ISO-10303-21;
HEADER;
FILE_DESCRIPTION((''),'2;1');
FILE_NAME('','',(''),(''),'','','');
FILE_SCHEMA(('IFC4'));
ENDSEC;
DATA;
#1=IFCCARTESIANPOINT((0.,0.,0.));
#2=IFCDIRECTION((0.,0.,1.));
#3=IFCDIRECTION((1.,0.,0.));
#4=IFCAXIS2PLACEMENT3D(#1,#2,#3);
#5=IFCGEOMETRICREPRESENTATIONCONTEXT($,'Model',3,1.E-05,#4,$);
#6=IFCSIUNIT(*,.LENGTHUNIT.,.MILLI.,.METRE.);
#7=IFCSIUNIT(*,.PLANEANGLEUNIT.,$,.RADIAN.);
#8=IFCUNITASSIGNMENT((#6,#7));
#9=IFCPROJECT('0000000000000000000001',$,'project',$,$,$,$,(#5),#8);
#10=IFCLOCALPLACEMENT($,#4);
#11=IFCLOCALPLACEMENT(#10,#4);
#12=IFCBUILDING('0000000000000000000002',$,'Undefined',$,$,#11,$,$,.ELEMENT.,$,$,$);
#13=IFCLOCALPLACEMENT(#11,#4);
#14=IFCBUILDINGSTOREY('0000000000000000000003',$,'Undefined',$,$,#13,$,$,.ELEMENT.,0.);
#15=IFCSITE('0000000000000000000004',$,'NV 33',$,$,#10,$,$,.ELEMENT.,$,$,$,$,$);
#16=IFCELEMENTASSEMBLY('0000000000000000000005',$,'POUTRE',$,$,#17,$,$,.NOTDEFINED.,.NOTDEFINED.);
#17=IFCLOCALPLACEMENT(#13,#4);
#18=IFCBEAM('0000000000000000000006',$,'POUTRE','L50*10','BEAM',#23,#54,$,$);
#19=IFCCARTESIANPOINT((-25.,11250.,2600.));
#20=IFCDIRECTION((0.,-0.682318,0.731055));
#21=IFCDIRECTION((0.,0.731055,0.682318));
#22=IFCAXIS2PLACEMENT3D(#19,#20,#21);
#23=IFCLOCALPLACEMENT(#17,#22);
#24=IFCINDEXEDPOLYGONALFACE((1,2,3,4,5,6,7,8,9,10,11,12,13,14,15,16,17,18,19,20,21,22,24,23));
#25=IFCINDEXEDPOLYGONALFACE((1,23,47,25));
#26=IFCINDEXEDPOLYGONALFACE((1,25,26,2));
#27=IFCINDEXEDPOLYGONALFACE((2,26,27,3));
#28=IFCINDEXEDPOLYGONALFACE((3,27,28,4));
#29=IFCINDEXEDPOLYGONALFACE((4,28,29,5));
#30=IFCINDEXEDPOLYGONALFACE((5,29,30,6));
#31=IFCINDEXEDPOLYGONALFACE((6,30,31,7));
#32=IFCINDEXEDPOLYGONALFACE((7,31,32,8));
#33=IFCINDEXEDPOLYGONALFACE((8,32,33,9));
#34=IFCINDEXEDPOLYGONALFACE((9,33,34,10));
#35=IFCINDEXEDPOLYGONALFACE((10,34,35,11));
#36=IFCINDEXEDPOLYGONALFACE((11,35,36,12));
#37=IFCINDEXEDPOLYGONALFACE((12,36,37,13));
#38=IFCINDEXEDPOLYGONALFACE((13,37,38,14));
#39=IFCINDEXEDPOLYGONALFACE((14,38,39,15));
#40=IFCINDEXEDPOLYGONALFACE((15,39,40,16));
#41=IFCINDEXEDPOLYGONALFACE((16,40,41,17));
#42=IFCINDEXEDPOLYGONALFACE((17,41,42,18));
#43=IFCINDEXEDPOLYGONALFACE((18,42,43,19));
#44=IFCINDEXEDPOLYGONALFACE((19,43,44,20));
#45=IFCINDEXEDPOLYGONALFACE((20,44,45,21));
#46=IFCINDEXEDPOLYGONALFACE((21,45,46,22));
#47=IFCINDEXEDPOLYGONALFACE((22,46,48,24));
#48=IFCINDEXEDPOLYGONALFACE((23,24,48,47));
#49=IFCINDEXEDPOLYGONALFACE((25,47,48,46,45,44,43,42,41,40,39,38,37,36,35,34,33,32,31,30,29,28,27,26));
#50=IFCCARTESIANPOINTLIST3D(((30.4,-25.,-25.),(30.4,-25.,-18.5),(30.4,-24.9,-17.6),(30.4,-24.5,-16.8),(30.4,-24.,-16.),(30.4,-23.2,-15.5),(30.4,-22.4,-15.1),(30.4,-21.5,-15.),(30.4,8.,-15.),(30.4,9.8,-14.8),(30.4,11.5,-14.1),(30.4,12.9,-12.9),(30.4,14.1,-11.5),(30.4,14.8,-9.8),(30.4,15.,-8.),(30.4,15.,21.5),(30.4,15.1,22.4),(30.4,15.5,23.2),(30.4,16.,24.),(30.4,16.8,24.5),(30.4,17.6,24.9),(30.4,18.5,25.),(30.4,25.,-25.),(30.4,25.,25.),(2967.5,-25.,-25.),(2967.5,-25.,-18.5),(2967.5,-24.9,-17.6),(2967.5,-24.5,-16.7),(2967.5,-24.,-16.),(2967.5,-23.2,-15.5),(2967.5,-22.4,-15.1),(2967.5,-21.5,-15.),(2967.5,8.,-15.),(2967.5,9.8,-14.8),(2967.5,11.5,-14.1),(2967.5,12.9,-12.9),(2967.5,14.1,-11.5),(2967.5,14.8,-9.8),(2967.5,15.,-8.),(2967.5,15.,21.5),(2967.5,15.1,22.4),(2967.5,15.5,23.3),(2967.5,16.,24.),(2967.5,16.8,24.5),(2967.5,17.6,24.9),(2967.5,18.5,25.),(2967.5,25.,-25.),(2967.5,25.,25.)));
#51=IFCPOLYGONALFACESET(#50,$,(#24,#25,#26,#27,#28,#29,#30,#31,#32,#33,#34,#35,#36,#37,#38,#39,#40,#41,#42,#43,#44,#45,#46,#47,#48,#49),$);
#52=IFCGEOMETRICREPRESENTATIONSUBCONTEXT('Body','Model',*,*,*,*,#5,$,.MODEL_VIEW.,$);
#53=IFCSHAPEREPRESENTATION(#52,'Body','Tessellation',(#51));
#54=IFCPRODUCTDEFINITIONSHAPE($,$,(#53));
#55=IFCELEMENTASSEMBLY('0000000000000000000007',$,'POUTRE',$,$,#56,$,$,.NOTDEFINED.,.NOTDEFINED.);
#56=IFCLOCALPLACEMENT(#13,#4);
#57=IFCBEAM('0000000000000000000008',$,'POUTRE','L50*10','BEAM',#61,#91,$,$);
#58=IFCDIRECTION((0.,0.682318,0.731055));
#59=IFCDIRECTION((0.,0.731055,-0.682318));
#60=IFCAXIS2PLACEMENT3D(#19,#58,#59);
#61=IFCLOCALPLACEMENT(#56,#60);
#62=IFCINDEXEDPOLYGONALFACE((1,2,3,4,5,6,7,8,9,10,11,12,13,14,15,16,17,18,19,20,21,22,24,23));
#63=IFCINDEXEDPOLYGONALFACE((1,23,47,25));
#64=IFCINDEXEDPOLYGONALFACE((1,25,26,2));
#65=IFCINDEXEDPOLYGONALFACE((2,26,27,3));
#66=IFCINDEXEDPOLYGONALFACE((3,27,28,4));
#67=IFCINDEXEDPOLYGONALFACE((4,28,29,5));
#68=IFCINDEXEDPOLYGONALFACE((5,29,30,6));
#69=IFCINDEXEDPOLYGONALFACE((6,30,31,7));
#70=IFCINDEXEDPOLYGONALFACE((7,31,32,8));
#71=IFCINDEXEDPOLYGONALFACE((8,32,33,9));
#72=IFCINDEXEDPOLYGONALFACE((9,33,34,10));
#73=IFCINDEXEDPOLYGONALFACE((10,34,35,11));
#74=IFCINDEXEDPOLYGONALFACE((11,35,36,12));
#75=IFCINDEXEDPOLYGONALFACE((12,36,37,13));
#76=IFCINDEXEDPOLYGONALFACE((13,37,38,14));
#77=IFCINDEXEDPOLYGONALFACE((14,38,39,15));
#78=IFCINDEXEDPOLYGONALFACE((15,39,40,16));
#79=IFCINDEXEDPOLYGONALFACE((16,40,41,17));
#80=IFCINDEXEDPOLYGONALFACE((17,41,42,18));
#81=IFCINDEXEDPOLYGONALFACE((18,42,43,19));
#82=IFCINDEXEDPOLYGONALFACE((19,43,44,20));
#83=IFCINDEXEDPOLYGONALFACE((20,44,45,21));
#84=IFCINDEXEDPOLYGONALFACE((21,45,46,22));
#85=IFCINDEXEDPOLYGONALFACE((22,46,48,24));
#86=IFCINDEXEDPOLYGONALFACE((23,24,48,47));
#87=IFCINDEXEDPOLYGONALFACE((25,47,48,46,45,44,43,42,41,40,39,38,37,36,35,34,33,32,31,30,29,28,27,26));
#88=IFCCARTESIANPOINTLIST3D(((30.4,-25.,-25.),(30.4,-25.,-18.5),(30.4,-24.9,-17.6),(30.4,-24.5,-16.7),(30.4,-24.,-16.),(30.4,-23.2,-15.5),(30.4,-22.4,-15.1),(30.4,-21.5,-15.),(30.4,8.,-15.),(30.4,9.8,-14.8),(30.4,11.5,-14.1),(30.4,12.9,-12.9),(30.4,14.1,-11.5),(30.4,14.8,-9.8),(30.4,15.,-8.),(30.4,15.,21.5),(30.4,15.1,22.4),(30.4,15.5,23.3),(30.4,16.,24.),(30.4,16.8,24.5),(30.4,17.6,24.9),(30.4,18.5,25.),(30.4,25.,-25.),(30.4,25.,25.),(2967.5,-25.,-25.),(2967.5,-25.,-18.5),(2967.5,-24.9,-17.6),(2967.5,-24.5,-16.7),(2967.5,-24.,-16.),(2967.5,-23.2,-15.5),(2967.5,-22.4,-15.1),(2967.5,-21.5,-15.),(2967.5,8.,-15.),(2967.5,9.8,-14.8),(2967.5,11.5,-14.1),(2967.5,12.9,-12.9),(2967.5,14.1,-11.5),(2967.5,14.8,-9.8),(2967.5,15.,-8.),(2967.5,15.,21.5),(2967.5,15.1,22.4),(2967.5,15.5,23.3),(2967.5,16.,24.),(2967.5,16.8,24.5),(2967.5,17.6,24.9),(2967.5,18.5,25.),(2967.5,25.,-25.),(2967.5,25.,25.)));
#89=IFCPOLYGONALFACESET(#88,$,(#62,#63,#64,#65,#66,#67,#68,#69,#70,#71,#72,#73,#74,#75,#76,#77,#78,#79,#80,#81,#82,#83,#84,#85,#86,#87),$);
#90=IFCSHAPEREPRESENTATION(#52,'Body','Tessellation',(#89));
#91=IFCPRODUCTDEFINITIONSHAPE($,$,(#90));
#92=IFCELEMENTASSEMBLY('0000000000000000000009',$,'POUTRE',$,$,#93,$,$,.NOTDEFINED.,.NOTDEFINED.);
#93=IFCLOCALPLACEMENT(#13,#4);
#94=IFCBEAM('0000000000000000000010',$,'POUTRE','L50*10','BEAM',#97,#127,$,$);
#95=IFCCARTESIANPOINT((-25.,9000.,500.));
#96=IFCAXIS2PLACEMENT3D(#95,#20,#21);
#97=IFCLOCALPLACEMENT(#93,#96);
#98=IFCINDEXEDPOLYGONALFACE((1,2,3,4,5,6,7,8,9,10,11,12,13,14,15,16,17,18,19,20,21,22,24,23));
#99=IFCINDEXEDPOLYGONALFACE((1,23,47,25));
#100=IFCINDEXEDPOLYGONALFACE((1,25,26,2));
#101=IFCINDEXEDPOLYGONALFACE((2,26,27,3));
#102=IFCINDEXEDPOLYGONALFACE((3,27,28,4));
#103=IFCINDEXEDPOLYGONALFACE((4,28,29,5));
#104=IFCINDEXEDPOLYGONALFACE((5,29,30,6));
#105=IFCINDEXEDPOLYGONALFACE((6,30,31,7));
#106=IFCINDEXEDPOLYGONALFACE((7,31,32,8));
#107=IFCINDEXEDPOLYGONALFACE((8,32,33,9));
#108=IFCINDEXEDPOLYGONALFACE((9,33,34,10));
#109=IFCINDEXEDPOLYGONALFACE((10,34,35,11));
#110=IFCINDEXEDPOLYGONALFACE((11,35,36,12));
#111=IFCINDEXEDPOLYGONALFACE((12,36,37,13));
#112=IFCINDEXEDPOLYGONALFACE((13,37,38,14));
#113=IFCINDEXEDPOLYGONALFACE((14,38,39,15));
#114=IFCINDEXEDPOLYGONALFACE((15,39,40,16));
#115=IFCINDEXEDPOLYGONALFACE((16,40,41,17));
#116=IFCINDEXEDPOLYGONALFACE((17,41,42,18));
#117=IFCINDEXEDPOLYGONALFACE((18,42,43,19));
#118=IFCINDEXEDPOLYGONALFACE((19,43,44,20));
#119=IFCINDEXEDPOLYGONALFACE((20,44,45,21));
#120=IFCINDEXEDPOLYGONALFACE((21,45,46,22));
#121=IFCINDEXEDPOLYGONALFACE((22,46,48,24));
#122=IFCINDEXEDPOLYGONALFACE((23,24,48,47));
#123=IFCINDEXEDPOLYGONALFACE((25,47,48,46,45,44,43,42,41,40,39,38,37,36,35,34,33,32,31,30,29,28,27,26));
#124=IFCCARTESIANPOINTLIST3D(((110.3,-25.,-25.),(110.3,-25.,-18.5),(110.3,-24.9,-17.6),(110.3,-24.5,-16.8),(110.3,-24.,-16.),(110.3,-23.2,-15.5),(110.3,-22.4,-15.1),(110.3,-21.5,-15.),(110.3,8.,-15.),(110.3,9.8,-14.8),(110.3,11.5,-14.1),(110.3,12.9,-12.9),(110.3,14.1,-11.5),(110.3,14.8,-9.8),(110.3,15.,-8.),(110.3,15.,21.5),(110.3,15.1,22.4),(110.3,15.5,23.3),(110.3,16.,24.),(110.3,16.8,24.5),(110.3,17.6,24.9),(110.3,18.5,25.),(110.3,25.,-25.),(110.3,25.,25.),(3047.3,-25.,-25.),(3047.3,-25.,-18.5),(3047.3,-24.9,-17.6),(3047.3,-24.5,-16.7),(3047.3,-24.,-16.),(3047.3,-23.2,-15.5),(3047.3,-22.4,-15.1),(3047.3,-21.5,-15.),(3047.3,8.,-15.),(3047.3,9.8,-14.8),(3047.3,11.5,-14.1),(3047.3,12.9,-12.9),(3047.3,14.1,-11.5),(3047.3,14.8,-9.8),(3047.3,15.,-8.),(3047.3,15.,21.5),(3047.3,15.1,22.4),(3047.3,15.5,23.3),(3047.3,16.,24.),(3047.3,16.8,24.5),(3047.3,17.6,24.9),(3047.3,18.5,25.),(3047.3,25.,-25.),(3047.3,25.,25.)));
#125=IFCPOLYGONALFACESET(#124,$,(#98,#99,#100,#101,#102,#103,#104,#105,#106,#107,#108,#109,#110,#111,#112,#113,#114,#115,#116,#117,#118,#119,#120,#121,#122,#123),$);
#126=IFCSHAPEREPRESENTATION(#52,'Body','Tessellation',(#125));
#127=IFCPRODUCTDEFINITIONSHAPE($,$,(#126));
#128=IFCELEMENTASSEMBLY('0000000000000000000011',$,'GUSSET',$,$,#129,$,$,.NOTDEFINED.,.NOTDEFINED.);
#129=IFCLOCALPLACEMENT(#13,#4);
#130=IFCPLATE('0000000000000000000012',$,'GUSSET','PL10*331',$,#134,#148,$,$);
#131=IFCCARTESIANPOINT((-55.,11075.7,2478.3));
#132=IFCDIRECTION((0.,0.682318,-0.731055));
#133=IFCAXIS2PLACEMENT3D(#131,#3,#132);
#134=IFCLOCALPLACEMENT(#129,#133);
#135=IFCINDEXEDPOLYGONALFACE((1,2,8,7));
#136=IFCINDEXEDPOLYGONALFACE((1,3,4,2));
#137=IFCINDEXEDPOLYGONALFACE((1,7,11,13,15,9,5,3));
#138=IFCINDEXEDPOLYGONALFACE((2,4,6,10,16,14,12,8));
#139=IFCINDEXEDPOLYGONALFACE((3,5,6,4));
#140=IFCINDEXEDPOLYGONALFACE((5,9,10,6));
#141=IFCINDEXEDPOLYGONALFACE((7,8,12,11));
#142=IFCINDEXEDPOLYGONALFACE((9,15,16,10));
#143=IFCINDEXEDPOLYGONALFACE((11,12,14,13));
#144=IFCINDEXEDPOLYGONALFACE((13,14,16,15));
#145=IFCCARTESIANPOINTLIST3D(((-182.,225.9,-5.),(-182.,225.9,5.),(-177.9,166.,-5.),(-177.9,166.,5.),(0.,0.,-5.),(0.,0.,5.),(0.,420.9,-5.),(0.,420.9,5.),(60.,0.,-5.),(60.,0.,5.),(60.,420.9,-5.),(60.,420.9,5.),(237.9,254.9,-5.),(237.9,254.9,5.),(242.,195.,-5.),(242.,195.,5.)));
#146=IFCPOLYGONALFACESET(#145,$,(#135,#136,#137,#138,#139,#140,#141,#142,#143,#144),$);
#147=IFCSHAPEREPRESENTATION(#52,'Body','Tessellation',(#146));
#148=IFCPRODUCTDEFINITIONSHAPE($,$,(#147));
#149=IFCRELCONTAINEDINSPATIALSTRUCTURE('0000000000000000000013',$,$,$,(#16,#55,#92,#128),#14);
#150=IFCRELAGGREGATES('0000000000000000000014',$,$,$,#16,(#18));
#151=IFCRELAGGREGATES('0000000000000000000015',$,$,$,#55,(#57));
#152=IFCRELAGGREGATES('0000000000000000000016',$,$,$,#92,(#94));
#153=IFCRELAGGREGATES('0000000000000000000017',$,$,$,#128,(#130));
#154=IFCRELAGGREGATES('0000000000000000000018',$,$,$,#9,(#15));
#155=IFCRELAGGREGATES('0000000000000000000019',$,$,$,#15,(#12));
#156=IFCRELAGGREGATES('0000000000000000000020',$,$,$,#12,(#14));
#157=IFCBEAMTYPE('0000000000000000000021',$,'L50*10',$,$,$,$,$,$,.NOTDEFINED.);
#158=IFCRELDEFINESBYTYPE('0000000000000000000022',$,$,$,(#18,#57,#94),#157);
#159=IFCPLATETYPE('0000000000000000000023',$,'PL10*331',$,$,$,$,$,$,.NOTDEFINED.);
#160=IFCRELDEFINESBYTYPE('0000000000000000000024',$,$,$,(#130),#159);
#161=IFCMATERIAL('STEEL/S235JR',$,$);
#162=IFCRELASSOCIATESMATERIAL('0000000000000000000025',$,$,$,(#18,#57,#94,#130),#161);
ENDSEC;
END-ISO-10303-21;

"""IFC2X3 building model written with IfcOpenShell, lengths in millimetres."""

from ifc_helpers import new_model, si_unit, frame, origin_with_axes, origin_2d_with_axis, place, context, subcontext, project, spatial, polyline, l_section, outline, extrude, clip, halfspace, material, type_object, element, aggregate, save


model = new_model("IFC2X3")

# Units and contexts
model_context = context("Model", 3, precision=1e-05, world=origin_with_axes())
body_context = subcontext(model_context, "Body", "Model", "MODEL_VIEW")
ifc_project = project(units=[si_unit("LENGTHUNIT", "METRE", prefix="MILLI"), si_unit("PLANEANGLEUNIT", "RADIAN")], contexts=[model_context])

# Site, building, storey
site_placement = place(None, origin_with_axes())
site = spatial("IfcSite", under=ifc_project, at=site_placement, Name="NV 33", CompositionType="ELEMENT")
building_placement = place(site_placement, origin_with_axes())
building = spatial("IfcBuilding", under=site, at=building_placement, Name="Undefined", CompositionType="ELEMENT")
storey_placement = place(building_placement, origin_with_axes())
storey = spatial("IfcBuildingStorey", under=building, at=storey_placement, Name="Undefined", CompositionType="ELEMENT", Elevation=0.0)

# Element assemblies, beams
assembly_1_placement = place(storey_placement, origin_with_axes())
assembly_1 = element("IfcElementAssembly", 1, at=assembly_1_placement, inside=storey, Name="POUTRE", AssemblyPlace="NOTDEFINED", PredefinedType="NOTDEFINED")
ifc_material_1 = material(Name="STEEL/S235JR")
beam_type_1 = type_object("IfcBeamType", Name="L50*10", PredefinedType="NOTDEFINED")
beam_1_placement = place(assembly_1_placement, frame((-25.0, 11250.0, 2600.0), z_axis=(0.0, -0.682318, 0.731055), x_axis=(0.0, 0.731055, 0.682318)))
beam_1 = element("IfcBeam", 2, at=beam_1_placement, type_object=beam_type_1, material=ifc_material_1, Name="POUTRE", Description="L50*10", ObjectType="BEAM", context=body_context, shape_type="Clipping", body=[
    clip(clip(extrude(l_section(Depth=50.0, Width=50.0, Thickness=10.0, FilletRadius=7.0, EdgeRadius=3.5, at=origin_2d_with_axis()), frame((3077.7, 0.0, 0.0), z_axis=(-1.0, 0.0, 0.0), x_axis=(0.0, -1.0, 0.0)), (0.0, 0.0, 1.0), 3097.7), halfspace(frame((2967.5, 31.0, 0.0), z_axis=(-1.0, 0.0, 0.0), x_axis=(0.0, 0.0, 1.0)), True)), halfspace(frame((30.4, 0.0, 25.0), z_axis=(1.0, 0.0, 0.0), x_axis=(0.0, 1.0, 0.0)), True)),
])
assembly_2_placement = place(storey_placement, origin_with_axes())
assembly_2 = element("IfcElementAssembly", 3, at=assembly_2_placement, inside=storey, Name="POUTRE", AssemblyPlace="NOTDEFINED", PredefinedType="NOTDEFINED")
beam_2_placement = place(assembly_2_placement, frame((-25.0, 11250.0, 2600.0), z_axis=(0.0, 0.682318, 0.731055), x_axis=(0.0, 0.731055, -0.682318)))
beam_2 = element("IfcBeam", 4, at=beam_2_placement, type_object=beam_type_1, material=ifc_material_1, Name="POUTRE", Description="L50*10", ObjectType="BEAM", context=body_context, shape_type="Clipping", body=[
    clip(clip(extrude(l_section(Depth=50.0, Width=50.0, Thickness=10.0, FilletRadius=7.0, EdgeRadius=3.5, at=origin_2d_with_axis()), frame((3077.7, 0.0, 0.0), z_axis=(-1.0, 0.0, 0.0), x_axis=(0.0, -1.0, 0.0)), (0.0, 0.0, 1.0), 3097.7), halfspace(frame((2967.5, 31.0, 0.0), z_axis=(-1.0, 0.0, 0.0), x_axis=(0.0, 0.0, 1.0)), True)), halfspace(frame((30.4, 0.0, 25.0), z_axis=(1.0, 0.0, 0.0), x_axis=(0.0, 1.0, 0.0)), True)),
])
assembly_3_placement = place(storey_placement, origin_with_axes())
assembly_3 = element("IfcElementAssembly", 5, at=assembly_3_placement, inside=storey, Name="POUTRE", AssemblyPlace="NOTDEFINED", PredefinedType="NOTDEFINED")
beam_3_placement = place(assembly_3_placement, frame((-25.0, 9000.0, 500.0), z_axis=(0.0, -0.682318, 0.731055), x_axis=(0.0, 0.731055, 0.682318)))
beam_3 = element("IfcBeam", 6, at=beam_3_placement, type_object=beam_type_1, material=ifc_material_1, Name="POUTRE", Description="L50*10", ObjectType="BEAM", context=body_context, shape_type="Clipping", body=[
    clip(clip(extrude(l_section(Depth=50.0, Width=50.0, Thickness=10.0, FilletRadius=7.0, EdgeRadius=3.5, at=origin_2d_with_axis()), frame((3097.7, 0.0, 0.0), z_axis=(-1.0, 0.0, 0.0), x_axis=(0.0, -1.0, 0.0)), (0.0, 0.0, 1.0), 3097.7), halfspace(frame((3047.3, 0.0, -25.0), z_axis=(-1.0, 0.0, 0.0), x_axis=(0.0, 1.0, 0.0)), True)), halfspace(frame((110.3, 31.0, 0.0), z_axis=(1.0, 0.0, 0.0), x_axis=(0.0, 0.0, -1.0)), True)),
])

# Element assembly, plate
assembly_4_placement = place(storey_placement, origin_with_axes())
assembly_4 = element("IfcElementAssembly", 7, at=assembly_4_placement, inside=storey, Name="GUSSET", AssemblyPlace="NOTDEFINED", PredefinedType="NOTDEFINED")
plate_type_1 = type_object("IfcPlateType", Name="PL10*331", PredefinedType="NOTDEFINED")
plate_1_placement = place(assembly_4_placement, frame((-55.0, 11075.7, 2478.3), z_axis=(1.0, 0.0, 0.0), x_axis=(0.0, 0.682318, -0.731055)))
plate_1 = element("IfcPlate", 8, at=plate_1_placement, type_object=plate_type_1, material=ifc_material_1, Name="GUSSET", Description="PL10*331", context=body_context, shape_type="SweptSolid", body=[
    extrude(outline(polyline([(0.0, 0.0), (60.0, 0.0), (242.0, 195.0), (237.9, 254.9), (60.0, 420.9), (0.0, 420.9), (-182.0, 225.9), (-177.9, 166.0), (0.0, 0.0)])), frame((0.0, 0.0, -5.0), z_axis=(0.0, 0.0, 1.0), x_axis=(1.0, 0.0, 0.0)), (0.0, 0.0, 1.0), 10.0),
])

aggregate(assembly_1, [beam_1])
aggregate(assembly_2, [beam_2])
aggregate(assembly_3, [beam_3])

aggregate(assembly_4, [plate_1])

save(model, "model.ifc")
